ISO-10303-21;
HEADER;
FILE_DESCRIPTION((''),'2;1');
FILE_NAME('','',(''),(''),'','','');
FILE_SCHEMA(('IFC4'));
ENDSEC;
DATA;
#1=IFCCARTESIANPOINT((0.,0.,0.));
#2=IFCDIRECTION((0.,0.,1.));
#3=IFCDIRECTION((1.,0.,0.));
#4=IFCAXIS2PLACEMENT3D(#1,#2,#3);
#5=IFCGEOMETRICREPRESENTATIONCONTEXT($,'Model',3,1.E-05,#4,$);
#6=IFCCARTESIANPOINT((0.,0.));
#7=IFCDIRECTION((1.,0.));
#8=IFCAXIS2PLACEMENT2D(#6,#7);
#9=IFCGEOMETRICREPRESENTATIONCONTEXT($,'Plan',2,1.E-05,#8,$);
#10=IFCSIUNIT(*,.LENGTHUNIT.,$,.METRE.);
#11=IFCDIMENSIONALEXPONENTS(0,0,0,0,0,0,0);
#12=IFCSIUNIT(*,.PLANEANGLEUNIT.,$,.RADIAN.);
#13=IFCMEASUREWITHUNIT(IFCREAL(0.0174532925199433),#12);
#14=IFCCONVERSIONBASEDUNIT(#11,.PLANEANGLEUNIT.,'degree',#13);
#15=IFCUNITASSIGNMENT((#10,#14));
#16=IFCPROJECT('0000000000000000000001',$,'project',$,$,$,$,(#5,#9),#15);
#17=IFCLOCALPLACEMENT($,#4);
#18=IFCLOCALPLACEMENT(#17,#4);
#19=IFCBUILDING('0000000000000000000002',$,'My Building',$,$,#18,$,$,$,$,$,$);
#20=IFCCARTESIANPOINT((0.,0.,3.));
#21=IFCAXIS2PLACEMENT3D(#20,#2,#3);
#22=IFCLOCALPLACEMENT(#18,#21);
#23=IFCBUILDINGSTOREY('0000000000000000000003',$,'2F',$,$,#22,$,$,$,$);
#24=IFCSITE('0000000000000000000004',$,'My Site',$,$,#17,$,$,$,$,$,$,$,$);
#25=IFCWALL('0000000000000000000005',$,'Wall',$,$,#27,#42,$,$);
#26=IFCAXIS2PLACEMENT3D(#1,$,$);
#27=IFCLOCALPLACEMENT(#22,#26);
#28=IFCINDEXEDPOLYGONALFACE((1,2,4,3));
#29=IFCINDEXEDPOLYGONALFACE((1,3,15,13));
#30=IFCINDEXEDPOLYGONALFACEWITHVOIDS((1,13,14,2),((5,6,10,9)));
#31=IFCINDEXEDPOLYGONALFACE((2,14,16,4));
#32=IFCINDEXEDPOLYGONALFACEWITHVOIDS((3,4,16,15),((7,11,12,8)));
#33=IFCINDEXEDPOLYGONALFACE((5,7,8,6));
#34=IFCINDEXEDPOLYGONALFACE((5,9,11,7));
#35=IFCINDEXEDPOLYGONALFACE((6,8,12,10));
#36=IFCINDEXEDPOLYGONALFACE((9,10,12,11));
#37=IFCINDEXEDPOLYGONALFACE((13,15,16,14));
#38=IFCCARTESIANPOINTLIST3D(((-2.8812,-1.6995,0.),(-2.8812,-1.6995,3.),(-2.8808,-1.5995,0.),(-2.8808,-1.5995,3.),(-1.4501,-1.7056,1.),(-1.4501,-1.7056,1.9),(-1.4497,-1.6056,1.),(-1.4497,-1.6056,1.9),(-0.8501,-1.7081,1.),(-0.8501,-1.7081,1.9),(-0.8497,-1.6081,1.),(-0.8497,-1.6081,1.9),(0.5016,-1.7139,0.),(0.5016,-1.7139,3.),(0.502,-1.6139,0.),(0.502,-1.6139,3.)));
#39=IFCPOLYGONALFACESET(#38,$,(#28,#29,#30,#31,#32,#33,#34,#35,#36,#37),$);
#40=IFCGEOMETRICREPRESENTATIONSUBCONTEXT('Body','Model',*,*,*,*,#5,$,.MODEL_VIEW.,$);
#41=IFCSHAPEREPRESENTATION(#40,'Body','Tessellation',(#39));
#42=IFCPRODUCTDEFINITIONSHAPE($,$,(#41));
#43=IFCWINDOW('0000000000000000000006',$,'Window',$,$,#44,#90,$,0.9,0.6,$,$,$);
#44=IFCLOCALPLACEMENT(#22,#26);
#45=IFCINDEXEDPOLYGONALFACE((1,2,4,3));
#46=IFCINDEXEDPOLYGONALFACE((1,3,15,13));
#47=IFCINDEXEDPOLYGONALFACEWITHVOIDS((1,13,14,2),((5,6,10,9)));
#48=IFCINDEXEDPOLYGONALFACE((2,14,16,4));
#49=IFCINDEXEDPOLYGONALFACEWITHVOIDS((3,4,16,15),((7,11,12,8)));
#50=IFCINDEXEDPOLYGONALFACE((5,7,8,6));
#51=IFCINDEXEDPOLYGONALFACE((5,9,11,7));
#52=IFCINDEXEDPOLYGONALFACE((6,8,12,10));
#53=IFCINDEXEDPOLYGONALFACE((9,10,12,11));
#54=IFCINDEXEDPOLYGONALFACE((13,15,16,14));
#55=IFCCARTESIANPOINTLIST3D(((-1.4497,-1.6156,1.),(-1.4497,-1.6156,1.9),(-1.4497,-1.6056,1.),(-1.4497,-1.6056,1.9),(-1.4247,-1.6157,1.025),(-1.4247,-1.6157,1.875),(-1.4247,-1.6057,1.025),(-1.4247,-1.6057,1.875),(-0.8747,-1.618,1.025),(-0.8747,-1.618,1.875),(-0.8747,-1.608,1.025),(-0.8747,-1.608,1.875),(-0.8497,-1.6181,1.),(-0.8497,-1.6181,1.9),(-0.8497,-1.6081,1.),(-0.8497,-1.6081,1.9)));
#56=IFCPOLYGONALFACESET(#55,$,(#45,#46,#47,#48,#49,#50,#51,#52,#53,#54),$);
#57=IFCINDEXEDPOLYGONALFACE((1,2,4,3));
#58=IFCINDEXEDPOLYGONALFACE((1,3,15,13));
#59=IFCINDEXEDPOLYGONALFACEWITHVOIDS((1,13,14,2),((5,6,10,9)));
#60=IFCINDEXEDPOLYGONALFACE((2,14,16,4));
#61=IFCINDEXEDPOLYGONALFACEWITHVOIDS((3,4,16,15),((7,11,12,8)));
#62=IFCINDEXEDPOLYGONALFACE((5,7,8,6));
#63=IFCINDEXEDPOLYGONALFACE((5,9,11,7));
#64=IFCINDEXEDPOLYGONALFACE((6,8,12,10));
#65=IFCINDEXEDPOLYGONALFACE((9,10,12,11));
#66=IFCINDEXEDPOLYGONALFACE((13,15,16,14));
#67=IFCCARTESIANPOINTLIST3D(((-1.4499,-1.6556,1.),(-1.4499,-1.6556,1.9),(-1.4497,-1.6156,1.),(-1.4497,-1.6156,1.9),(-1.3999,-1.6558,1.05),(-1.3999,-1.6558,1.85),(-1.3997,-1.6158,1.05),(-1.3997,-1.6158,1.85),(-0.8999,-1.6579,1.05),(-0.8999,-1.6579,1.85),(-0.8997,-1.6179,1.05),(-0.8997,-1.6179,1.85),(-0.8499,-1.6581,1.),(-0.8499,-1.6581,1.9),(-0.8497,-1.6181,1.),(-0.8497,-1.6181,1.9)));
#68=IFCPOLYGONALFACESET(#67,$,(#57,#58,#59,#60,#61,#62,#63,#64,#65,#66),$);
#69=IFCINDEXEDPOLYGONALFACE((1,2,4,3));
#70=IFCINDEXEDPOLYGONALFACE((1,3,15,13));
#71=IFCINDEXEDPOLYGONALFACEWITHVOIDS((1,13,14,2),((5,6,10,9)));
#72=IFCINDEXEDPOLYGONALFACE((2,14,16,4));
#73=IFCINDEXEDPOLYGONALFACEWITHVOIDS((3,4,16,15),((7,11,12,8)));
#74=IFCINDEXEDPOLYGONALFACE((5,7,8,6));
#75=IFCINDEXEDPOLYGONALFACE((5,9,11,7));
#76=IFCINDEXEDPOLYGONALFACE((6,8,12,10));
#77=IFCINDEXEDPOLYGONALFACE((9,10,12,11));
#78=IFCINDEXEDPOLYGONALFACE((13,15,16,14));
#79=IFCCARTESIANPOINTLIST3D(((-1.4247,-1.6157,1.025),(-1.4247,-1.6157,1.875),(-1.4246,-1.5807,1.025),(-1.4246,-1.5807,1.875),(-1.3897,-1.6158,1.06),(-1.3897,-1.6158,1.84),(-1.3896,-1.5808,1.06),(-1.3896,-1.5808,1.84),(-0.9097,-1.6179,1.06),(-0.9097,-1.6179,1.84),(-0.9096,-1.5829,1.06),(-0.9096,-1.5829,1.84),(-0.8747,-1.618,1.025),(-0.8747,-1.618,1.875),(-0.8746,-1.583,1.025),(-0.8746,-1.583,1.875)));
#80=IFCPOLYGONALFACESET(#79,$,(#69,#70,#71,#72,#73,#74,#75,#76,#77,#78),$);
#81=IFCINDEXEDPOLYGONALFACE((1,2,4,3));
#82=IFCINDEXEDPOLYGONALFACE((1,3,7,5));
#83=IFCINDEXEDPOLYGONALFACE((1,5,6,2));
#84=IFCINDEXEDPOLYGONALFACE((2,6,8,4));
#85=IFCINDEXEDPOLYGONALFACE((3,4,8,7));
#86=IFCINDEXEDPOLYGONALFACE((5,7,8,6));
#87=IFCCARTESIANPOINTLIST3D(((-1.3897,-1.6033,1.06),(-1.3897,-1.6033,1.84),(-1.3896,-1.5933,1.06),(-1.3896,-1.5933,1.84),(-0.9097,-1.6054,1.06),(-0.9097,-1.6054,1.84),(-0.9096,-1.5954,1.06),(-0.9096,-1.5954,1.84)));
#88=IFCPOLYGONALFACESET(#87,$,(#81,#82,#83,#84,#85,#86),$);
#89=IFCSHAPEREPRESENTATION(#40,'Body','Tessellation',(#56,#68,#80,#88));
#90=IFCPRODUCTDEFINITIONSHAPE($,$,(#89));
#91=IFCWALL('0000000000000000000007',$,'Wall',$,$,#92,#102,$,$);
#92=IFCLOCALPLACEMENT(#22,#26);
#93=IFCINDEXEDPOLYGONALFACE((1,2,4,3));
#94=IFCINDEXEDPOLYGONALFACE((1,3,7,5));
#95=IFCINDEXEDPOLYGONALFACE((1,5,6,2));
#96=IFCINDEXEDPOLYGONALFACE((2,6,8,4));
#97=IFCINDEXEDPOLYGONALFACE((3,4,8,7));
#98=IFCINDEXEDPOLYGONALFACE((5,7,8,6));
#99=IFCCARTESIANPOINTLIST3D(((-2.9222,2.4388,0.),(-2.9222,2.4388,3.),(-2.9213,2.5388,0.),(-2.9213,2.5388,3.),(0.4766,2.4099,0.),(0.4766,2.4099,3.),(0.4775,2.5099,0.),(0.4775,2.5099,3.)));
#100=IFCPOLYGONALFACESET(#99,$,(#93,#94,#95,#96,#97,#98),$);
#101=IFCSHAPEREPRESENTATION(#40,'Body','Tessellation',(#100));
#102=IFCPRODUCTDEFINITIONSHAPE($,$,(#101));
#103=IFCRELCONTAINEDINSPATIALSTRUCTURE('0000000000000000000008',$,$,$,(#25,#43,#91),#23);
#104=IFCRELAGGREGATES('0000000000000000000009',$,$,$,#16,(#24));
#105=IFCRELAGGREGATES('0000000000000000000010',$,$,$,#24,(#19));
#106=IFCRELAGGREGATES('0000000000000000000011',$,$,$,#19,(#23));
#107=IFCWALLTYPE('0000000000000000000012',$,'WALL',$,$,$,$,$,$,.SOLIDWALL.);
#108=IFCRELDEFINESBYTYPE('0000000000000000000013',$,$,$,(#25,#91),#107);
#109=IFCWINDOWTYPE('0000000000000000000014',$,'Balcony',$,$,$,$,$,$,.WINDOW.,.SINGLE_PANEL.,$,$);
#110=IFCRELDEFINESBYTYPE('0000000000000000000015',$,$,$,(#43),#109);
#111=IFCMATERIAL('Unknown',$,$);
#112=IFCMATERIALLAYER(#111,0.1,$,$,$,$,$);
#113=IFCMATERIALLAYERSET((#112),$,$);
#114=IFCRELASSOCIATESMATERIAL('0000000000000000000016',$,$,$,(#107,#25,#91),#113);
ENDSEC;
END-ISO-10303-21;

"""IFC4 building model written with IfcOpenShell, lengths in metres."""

from ifc_helpers import new_model, entity, si_unit, converted_unit, frame, origin_with_axes, origin_2d_with_axis, place, context, subcontext, project, spatial, line, indexed_curve, outline, extrude, shape, source, transform, mapped, material, layer, layer_set, layer_usage, type_object, type_shapes, element, fill, save


model = new_model("IFC4")

# Units and contexts
model_context = context("Model", 3, precision=1e-05, world=origin_with_axes())
plan_context = context("Plan", 2, precision=1e-05, world=origin_2d_with_axis())
body_context_1 = subcontext(model_context, "Body", "Model", "MODEL_VIEW")
body_context_2 = subcontext(plan_context, "Body", "Plan", "PLAN_VIEW")
ifc_project = project(units=[si_unit("LENGTHUNIT", "METRE"), converted_unit("PLANEANGLEUNIT", "degree", entity("IfcReal", 0.0174532925199433), si_unit("PLANEANGLEUNIT", "RADIAN"), dimensions=[0, 0, 0, 0, 0, 0, 0])], contexts=[model_context, plan_context])

# Site, building, storey
site_placement = place(None, origin_with_axes())
site = spatial("IfcSite", under=ifc_project, at=site_placement, Name="My Site")
building_placement = place(site_placement, origin_with_axes())
building = spatial("IfcBuilding", under=site, at=building_placement, Name="My Building")
storey_placement = place(building_placement, frame((0.0, 0.0, 3.0), z_axis=(0.0, 0.0, 1.0), x_axis=(1.0, 0.0, 0.0)))
storey = spatial("IfcBuildingStorey", under=building, at=storey_placement, Name="2F")

# Shared definitions
ifc_material = material(Name="Unknown")

# Wall, opening, window
ifc_layer = layer(ifc_material, 0.1)
ifc_layer_set = layer_set([ifc_layer])
ifc_layer_usage_1 = layer_usage(ifc_layer_set, "AXIS2", "POSITIVE", 0.0)
wall_type = type_object("IfcWallType", Name="WALL", PredefinedType="SOLIDWALL", material=ifc_layer_set)
wall_1_placement = place(storey_placement, frame((-2.8812, -1.6995, 0.0), z_axis=(0.0, 0.0, 1.0), x_axis=(0.999991, -0.004277, 0.0)))
wall_1 = element("IfcWall", 1, at=wall_1_placement, inside=storey, type_object=wall_type, material=ifc_layer_usage_1, Name="Wall", context=body_context_1, shape_type="SweptSolid", body=[
    extrude(outline(indexed_curve([(0.0, 0.0), (0.0, 0.1), (3.3828, 0.1), (3.3828, 0.0)], segments=[line(1, 2, 3, 4, 1)])), origin_with_axes(), (0.0, 0.0, 1.0), 3.0),
])
shared_shape_1 = source(origin_with_axes(), body_context_1, "Body", "SweptSolid", [
    extrude(outline(indexed_curve([(0.0, 0.0), (0.6, 0.0), (0.6, 0.9), (0.0, 0.9)], segments=[line(1, 2, 3, 4, 1)])), frame((0.0, -0.6, 0.0), z_axis=(0.0, -1.0, 0.0), x_axis=(1.0, 0.0, 0.0)), (0.0, 0.0, -1.0), 1.2),
])
opening_1_placement = place(wall_1_placement, frame((1.4311, 0.0, 1.0), z_axis=(0.0, 0.0, 1.0), x_axis=(1.0, 0.0, 0.0)))
opening_1 = element("IfcOpeningElement", 2, at=opening_1_placement, cuts=wall_1, PredefinedType="OPENING", context=body_context_1, shape_type="MappedRepresentation", body=[
    mapped(shared_shape_1, transform((0.0, 0.0, 0.0), x_axis=(1.0, 0.0, 0.0), y_axis=(0.0, 1.0, 0.0), z_axis=(0.0, 0.0, 1.0), scale=1.0)),
])
window_type = type_object("IfcWindowType", Name="Balcony", PartitioningType="SINGLE_PANEL", PredefinedType="WINDOW")
shared_shape_2 = source(origin_with_axes(), body_context_1, "Body", "SweptSolid", [
    extrude(outline(indexed_curve([(0.0, 0.0), (0.6, 0.0), (0.6, 0.9), (0.0, 0.9)], segments=[line(1, 2, 3, 4, 1)]), holes=[indexed_curve([(0.025, 0.025), (0.575, 0.025), (0.575, 0.875), (0.025, 0.875)], segments=[line(1, 2, 3, 4, 1)])]), frame((0.0, 0.09, 0.0), z_axis=(0.0, -1.0, 0.0), x_axis=(1.0, 0.0, 0.0)), (0.0, 0.0, -1.0), 0.01),
    extrude(outline(indexed_curve([(0.0, 0.0), (0.6, 0.0), (0.6, 0.9), (0.0, 0.9)], segments=[line(1, 2, 3, 4, 1)]), holes=[indexed_curve([(0.05, 0.05), (0.55, 0.05), (0.55, 0.85), (0.05, 0.85)], segments=[line(1, 2, 3, 4, 1)])]), frame((0.0, 0.05, 0.0), z_axis=(0.0, -1.0, 0.0), x_axis=(1.0, 0.0, 0.0)), (0.0, 0.0, -1.0), 0.04),
    extrude(outline(indexed_curve([(0.0, 0.0), (0.55, 0.0), (0.55, 0.85), (0.0, 0.85)], segments=[line(1, 2, 3, 4, 1)]), holes=[indexed_curve([(0.035, 0.035), (0.515, 0.035), (0.515, 0.815), (0.035, 0.815)], segments=[line(1, 2, 3, 4, 1)])]), frame((0.025, 0.09, 0.025), z_axis=(0.0, -1.0, 0.0), x_axis=(1.0, 0.0, 0.0)), (0.0, 0.0, -1.0), 0.035),
    extrude(outline(indexed_curve([(0.035, 0.035), (0.515, 0.035), (0.515, 0.815), (0.035, 0.815)], segments=[line(1, 2, 3, 4, 1)])), frame((0.025, 0.1025, 0.025), z_axis=(0.0, -1.0, 0.0), x_axis=(1.0, 0.0, 0.0)), (0.0, 0.0, -1.0), 0.01),
])
shared_shape_3 = source(origin_with_axes(), body_context_2, "Body", "Curve2D", [
    entity("IfcIndexedPolyCurve", entity("IfcCartesianPointList2D", [[0.05, 0.05], [0.55, 0.05]])),
    entity("IfcIndexedPolyCurve", entity("IfcCartesianPointList2D", [[0.0, 0.1], [0.025, 0.1], [0.025, 0.09], [0.05, 0.09], [0.05, 0.05], [0.0, 0.05]]), [entity("IfcLineIndex", [1, 2, 3, 4, 5, 6, 1])]),
    entity("IfcIndexedPolyCurve", entity("IfcCartesianPointList2D", [[0.6, 0.1], [0.575, 0.1], [0.575, 0.09], [0.55, 0.09], [0.55, 0.05], [0.6, 0.05]]), [entity("IfcLineIndex", [1, 2, 3, 4, 5, 6, 1])]),
    entity("IfcIndexedPolyCurve", entity("IfcCartesianPointList2D", [[0.025, 0.09], [0.06, 0.09], [0.06, 0.125], [0.025, 0.125]]), [entity("IfcLineIndex", [1, 2, 3, 4, 1])]),
    entity("IfcIndexedPolyCurve", entity("IfcCartesianPointList2D", [[0.575, 0.09], [0.54, 0.09], [0.54, 0.125], [0.575, 0.125]]), [entity("IfcLineIndex", [1, 2, 3, 4, 1])]),
    entity("IfcIndexedPolyCurve", entity("IfcCartesianPointList2D", [[0.06, 0.09], [0.54, 0.09]])),
    entity("IfcIndexedPolyCurve", entity("IfcCartesianPointList2D", [[0.06, 0.125], [0.54, 0.125]])),
    entity("IfcIndexedPolyCurve", entity("IfcCartesianPointList2D", [[0.06, 0.1075], [0.54, 0.1075]])),
])
type_shapes(window_type, [shared_shape_2, shared_shape_3])
window_placement = place(opening_1_placement, frame((0.0, 0.0, 0.0), z_axis=(0.0, 0.0, 1.0), x_axis=(1.0, 0.0, 0.0)))
window = element("IfcWindow", 3, at=window_placement, inside=storey, type_object=window_type, Name="Window", OverallHeight=0.9, OverallWidth=0.6, shapes=[
    shape(body_context_1, "Body", "MappedRepresentation", [mapped(shared_shape_2, transform((0.0, 0.0, 0.0), x_axis=(1.0, 0.0, 0.0), y_axis=(0.0, 1.0, 0.0), z_axis=(0.0, 0.0, 1.0), scale=1.0))]),
    shape(body_context_2, "Body", "MappedRepresentation", [mapped(shared_shape_3, transform((0.0, 0.0, 0.0), x_axis=(1.0, 0.0, 0.0), y_axis=(0.0, 1.0, 0.0), z_axis=(0.0, 0.0, 1.0), scale=1.0))]),
])
fill(opening_1, window)

# Wall
ifc_layer_usage_2 = layer_usage(ifc_layer_set, "AXIS2", "POSITIVE", 0.0)
wall_2_placement = place(storey_placement, frame((-2.9222, 2.4388, 0.0), z_axis=(0.0, 0.0, 1.0), x_axis=(0.999964, -0.008491, 0.0)))
element("IfcWall", 4, at=wall_2_placement, inside=storey, type_object=wall_type, material=ifc_layer_usage_2, Name="Wall", context=body_context_1, shape_type="SweptSolid", body=[
    extrude(outline(indexed_curve([(0.0, 0.0), (0.0, 0.1), (3.3989, 0.1), (3.3989, 0.0)], segments=[line(1, 2, 3, 4, 1)])), origin_with_axes(), (0.0, 0.0, 1.0), 3.0),
])

save(model, "model.ifc")
